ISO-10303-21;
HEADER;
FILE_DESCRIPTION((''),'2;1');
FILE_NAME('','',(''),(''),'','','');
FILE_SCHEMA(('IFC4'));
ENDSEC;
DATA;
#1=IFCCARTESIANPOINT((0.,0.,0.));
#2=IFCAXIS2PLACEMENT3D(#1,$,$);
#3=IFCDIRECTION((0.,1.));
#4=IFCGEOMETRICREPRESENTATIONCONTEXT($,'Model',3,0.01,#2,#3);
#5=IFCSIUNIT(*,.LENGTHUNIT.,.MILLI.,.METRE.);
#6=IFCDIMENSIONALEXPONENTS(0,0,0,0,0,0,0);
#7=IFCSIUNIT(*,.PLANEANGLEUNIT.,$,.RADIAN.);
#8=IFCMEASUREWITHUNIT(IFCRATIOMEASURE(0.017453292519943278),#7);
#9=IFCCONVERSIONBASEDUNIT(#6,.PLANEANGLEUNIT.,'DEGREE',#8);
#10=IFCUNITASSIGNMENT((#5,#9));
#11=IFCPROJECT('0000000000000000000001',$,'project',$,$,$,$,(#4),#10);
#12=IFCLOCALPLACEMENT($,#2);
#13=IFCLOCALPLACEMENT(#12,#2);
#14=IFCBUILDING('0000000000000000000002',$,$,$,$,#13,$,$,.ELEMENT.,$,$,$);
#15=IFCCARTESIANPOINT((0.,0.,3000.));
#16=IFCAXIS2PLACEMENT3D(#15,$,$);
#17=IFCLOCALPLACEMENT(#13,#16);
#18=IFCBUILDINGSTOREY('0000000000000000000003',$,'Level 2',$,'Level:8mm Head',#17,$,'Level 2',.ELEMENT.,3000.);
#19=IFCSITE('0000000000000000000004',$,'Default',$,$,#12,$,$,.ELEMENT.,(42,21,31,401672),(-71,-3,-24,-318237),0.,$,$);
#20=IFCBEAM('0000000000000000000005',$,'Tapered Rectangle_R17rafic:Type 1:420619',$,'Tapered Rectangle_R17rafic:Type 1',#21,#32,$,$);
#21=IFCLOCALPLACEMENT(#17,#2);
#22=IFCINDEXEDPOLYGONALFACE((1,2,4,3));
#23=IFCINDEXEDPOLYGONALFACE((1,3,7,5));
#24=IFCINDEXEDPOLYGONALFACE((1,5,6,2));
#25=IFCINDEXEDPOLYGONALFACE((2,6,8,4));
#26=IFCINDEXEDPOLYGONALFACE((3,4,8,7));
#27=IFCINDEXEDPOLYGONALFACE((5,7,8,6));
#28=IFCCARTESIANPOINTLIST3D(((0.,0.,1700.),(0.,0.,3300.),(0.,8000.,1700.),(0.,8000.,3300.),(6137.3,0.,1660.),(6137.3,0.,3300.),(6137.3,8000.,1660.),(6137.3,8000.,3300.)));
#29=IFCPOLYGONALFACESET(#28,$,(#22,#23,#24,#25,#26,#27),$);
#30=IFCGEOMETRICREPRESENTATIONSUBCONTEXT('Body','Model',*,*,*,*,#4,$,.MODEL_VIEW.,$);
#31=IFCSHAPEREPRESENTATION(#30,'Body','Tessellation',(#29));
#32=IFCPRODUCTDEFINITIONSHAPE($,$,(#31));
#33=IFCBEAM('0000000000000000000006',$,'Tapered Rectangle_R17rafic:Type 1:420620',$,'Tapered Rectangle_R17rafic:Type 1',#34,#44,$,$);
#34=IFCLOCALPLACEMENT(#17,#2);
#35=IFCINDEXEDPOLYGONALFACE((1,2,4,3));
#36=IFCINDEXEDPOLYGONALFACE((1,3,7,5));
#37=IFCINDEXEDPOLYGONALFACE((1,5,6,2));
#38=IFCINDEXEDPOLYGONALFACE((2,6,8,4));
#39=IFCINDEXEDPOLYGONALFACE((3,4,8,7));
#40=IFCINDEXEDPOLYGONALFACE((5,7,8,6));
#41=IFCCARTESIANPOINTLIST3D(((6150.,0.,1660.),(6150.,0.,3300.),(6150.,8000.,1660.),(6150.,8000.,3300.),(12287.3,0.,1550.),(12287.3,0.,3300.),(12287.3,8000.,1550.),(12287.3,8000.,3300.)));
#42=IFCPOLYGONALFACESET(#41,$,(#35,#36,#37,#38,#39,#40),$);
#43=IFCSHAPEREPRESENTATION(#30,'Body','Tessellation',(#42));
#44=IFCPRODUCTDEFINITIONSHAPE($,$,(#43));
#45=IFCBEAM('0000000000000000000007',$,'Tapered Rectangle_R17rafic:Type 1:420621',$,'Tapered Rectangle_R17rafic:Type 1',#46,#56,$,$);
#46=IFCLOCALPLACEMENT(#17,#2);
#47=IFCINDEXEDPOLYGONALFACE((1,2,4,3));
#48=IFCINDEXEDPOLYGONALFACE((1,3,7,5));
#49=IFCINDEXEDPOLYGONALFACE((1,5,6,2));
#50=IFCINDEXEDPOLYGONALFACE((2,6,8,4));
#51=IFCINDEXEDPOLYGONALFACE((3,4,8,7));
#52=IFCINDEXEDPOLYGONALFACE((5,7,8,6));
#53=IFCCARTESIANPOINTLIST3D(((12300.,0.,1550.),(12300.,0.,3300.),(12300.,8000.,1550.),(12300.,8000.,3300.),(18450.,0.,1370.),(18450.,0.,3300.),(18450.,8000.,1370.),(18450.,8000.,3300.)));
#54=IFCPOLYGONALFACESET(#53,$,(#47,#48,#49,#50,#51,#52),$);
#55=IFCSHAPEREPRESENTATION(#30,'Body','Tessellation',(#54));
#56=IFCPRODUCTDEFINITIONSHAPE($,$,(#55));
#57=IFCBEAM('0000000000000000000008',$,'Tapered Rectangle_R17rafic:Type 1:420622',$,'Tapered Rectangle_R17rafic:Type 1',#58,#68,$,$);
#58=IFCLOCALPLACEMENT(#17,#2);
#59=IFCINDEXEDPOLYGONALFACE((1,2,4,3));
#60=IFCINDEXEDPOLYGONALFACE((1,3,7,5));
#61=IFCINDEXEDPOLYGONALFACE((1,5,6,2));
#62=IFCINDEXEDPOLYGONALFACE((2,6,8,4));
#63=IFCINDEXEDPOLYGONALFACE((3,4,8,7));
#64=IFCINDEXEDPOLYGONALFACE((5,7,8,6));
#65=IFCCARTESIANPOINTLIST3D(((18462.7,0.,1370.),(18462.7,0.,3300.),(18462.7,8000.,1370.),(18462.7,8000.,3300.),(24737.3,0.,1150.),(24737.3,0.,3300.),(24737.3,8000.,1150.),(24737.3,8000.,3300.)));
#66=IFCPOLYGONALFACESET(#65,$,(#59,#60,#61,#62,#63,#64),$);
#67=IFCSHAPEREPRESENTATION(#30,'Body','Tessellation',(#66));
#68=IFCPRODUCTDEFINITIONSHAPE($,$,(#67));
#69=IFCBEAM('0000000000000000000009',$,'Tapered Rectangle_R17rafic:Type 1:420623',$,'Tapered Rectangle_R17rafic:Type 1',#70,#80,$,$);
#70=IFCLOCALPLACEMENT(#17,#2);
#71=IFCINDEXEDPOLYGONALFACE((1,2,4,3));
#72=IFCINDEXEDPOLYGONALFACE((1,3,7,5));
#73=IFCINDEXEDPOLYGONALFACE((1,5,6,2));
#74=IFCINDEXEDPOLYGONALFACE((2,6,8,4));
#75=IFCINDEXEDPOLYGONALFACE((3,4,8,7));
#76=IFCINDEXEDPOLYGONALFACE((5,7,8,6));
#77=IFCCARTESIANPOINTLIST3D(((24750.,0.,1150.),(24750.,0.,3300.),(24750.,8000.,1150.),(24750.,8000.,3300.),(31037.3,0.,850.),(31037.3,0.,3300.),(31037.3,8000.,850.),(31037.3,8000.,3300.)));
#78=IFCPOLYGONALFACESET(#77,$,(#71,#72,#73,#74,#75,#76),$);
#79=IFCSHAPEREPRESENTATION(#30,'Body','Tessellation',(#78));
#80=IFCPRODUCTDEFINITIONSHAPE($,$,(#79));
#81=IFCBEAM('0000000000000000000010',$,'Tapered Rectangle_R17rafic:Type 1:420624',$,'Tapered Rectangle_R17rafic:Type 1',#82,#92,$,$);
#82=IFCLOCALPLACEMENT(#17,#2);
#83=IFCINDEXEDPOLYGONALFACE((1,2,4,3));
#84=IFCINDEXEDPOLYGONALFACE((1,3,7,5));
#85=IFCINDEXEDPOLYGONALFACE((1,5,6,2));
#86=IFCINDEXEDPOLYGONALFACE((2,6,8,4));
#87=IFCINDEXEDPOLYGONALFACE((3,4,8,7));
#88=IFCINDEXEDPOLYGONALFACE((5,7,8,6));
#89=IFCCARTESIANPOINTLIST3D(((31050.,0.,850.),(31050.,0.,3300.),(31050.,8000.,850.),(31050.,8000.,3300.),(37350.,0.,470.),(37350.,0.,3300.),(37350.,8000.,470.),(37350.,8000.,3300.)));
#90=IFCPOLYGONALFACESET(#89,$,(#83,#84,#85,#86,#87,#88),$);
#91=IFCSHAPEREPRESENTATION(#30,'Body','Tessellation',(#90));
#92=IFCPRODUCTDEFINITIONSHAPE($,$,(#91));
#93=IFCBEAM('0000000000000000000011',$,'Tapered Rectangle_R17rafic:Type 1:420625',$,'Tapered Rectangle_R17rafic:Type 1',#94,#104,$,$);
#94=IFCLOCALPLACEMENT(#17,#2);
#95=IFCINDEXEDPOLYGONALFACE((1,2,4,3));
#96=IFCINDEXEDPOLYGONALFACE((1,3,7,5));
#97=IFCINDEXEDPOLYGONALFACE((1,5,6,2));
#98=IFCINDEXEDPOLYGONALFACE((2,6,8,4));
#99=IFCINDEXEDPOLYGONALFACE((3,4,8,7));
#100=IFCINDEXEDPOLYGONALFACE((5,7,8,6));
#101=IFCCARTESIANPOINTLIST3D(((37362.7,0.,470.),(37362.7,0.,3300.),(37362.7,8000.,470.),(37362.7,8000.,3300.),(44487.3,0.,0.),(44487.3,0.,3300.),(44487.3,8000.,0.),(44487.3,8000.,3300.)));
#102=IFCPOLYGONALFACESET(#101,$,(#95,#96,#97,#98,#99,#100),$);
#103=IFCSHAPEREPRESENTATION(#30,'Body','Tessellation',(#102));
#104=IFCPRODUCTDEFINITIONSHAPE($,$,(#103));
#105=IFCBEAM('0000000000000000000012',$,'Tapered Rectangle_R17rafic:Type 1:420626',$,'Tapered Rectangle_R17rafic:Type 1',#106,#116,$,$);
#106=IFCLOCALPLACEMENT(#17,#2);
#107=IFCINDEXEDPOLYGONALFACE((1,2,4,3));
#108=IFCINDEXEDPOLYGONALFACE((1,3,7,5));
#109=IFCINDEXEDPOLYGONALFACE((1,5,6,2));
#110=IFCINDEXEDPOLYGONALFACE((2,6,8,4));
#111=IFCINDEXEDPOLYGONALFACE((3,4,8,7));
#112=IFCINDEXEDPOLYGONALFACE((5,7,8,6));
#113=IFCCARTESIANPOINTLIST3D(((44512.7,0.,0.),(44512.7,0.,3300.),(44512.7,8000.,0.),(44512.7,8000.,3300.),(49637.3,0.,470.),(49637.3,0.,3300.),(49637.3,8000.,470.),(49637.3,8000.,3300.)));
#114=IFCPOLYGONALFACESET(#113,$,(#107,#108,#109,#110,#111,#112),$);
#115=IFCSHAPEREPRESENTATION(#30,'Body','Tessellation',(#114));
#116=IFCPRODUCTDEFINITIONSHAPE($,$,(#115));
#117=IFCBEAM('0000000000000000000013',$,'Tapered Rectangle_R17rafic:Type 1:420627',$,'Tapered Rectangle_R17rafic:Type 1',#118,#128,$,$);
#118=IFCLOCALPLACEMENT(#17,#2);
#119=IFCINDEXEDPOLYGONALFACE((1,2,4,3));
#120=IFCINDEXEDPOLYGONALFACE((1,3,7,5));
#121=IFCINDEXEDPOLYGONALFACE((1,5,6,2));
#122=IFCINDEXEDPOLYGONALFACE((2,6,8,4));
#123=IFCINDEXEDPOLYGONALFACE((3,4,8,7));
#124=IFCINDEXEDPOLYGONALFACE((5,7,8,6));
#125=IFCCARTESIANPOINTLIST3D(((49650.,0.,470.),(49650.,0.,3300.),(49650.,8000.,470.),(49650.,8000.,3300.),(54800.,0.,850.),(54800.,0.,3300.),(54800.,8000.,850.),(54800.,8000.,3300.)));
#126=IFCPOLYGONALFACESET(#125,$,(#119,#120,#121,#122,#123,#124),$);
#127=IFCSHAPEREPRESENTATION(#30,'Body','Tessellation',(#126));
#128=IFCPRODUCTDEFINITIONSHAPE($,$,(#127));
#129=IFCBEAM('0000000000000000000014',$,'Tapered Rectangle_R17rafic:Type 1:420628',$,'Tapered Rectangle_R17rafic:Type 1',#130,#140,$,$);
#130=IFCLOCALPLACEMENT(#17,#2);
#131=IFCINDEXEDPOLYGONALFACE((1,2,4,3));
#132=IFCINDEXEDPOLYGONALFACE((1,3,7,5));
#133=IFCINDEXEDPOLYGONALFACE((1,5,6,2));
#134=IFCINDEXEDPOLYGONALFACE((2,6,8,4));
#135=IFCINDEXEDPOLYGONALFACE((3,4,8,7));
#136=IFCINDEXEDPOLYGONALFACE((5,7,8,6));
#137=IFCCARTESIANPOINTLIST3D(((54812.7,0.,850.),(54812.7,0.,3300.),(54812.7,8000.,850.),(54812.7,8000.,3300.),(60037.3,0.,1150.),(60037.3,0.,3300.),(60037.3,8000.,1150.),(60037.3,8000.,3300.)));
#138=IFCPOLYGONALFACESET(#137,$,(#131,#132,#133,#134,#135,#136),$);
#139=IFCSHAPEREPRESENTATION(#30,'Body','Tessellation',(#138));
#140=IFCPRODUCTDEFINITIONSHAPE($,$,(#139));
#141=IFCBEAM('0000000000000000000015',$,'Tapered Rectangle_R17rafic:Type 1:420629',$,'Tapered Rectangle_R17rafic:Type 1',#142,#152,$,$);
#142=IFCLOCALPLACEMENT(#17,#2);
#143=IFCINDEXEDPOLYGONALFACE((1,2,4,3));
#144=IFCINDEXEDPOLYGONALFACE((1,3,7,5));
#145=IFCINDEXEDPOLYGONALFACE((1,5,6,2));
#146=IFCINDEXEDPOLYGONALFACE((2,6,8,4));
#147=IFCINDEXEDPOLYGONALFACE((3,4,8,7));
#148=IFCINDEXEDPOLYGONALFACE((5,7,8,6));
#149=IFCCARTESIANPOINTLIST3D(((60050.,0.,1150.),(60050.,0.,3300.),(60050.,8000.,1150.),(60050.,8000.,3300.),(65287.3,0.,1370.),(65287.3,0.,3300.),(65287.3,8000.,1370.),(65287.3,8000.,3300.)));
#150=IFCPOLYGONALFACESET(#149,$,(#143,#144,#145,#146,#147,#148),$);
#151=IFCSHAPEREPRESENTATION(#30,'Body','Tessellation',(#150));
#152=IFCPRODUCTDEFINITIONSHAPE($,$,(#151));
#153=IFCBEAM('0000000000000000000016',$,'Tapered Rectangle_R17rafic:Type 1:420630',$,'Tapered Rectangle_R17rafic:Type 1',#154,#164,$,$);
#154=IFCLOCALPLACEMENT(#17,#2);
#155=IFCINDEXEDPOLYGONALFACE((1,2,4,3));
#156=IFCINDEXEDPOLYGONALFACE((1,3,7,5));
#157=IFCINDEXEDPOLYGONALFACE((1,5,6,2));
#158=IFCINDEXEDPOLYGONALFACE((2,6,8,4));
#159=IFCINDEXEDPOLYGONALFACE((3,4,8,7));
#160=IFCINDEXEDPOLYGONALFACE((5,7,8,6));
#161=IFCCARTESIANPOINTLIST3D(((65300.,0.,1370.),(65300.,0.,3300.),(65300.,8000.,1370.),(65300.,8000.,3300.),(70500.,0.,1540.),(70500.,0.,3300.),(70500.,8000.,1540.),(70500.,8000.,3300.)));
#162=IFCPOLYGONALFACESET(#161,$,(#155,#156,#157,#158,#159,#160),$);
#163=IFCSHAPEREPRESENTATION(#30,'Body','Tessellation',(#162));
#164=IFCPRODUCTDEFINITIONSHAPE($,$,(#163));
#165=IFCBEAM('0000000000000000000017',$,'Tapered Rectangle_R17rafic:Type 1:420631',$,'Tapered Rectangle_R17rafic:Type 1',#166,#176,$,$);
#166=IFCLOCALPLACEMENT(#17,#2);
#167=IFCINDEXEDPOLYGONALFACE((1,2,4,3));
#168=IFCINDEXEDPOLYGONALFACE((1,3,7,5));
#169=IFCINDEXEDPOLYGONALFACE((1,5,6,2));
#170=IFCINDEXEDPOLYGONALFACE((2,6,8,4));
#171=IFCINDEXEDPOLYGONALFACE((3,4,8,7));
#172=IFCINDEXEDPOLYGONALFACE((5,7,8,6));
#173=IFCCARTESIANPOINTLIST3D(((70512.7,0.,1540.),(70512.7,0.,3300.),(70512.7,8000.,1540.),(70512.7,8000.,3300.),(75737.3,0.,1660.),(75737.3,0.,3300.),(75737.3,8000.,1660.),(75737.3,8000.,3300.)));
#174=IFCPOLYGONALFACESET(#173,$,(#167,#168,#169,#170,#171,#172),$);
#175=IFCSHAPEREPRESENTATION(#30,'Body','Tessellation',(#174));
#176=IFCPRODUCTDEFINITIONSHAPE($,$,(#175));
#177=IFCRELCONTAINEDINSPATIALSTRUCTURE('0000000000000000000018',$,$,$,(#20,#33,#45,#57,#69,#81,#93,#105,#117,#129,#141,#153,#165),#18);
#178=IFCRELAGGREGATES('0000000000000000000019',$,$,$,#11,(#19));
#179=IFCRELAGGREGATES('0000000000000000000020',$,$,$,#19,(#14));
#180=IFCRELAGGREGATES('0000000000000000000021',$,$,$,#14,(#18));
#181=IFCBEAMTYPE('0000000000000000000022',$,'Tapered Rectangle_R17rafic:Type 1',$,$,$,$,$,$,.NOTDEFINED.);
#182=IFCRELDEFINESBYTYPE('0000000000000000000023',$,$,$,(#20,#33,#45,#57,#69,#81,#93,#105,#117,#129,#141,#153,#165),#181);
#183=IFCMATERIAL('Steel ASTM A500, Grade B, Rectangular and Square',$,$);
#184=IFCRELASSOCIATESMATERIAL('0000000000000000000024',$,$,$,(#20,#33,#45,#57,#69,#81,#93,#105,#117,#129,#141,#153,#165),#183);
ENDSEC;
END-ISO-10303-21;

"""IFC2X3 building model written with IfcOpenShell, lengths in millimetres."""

from ifc_helpers import new_model, entity, si_unit, converted_unit, direction, frame, frame_2d, origin, place, context, subcontext, project, spatial, rectangle, extrude, clip, halfspace, material, type_object, element, save


model = new_model("IFC2X3")

# Units and contexts
model_context = context("Model", 3, precision=0.01, world=origin(), true_north=direction((0.0, 1.0)))
body_context = subcontext(model_context, "Body", "Model", "MODEL_VIEW")
ifc_project = project(units=[si_unit("LENGTHUNIT", "METRE", prefix="MILLI"), converted_unit("PLANEANGLEUNIT", "DEGREE", entity("IfcRatioMeasure", 0.017453292519943278), si_unit("PLANEANGLEUNIT", "RADIAN"), dimensions=[0, 0, 0, 0, 0, 0, 0])], contexts=[model_context])

# Site, building, storey
site_placement = place(None, origin())
site = spatial("IfcSite", under=ifc_project, at=site_placement, Name="Default", CompositionType="ELEMENT", RefLatitude=(42, 21, 31, 401672), RefLongitude=(-71, -3, -24, -318237), RefElevation=0.0)
building_placement = place(site_placement, origin())
building = spatial("IfcBuilding", under=site, at=building_placement, CompositionType="ELEMENT")
storey_placement = place(building_placement, frame((0.0, 0.0, 3000.0)))
storey = spatial("IfcBuildingStorey", under=building, at=storey_placement, Name="Level 2", ObjectType="Level:8mm Head", LongName="Level 2", CompositionType="ELEMENT", Elevation=3000.0)

# Beams
ifc_material = material(Name="Steel ASTM A500, Grade B, Rectangular and Square")
beam_type = type_object("IfcBeamType", Name="Tapered Rectangle_R17rafic:Type 1", PredefinedType="NOTDEFINED")
beam_1_placement = place(storey_placement, frame((0.0, 4000.0, 3300.0)))
element("IfcBeam", 1, at=beam_1_placement, inside=storey, type_object=beam_type, material=ifc_material, Name="Tapered Rectangle_R17rafic:Type 1:420619", ObjectType="Tapered Rectangle_R17rafic:Type 1", context=body_context, shape_type="SweptSolid", body=[
    clip(extrude(rectangle(XDim=1640.0, YDim=8000.0, at=frame_2d((0.0, 0.0), x_axis=(0.0, 1.0))), frame((0.0, 0.0, -820.0), z_axis=(1.0, 0.0, 0.0), x_axis=(0.0, 1.0, 0.0)), (0.0, 0.0, 1.0), 6137.3), halfspace(frame((0.0, 0.0, -1600.0), z_axis=(-0.006517, 0.0, -0.999979), x_axis=(0.0, 1.0, 0.0)), False)),
])
beam_2_placement = place(storey_placement, frame((6150.0, 4000.0, 3300.0)))
element("IfcBeam", 2, at=beam_2_placement, inside=storey, type_object=beam_type, material=ifc_material, Name="Tapered Rectangle_R17rafic:Type 1:420620", ObjectType="Tapered Rectangle_R17rafic:Type 1", context=body_context, shape_type="SweptSolid", body=[
    clip(extrude(rectangle(XDim=1750.0, YDim=8000.0, at=frame_2d((0.0, 0.0), x_axis=(0.0, 1.0))), frame((0.0, 0.0, -875.0), z_axis=(1.0, 0.0, 0.0), x_axis=(0.0, 1.0, 0.0)), (0.0, 0.0, 1.0), 6137.3), halfspace(frame((0.0, 0.0, -1640.0), z_axis=(-0.01792, 0.0, -0.999839), x_axis=(0.0, 1.0, 0.0)), False)),
])
beam_3_placement = place(storey_placement, frame((12300.0, 4000.0, 3300.0)))
element("IfcBeam", 3, at=beam_3_placement, inside=storey, type_object=beam_type, material=ifc_material, Name="Tapered Rectangle_R17rafic:Type 1:420621", ObjectType="Tapered Rectangle_R17rafic:Type 1", context=body_context, shape_type="SweptSolid", body=[
    clip(extrude(rectangle(XDim=1930.0, YDim=8000.0, at=frame_2d((0.0, 0.0), x_axis=(0.0, 1.0))), frame((0.0, 0.0, -965.0), z_axis=(1.0, 0.0, 0.0), x_axis=(0.0, 1.0, 0.0)), (0.0, 0.0, 1.0), 6150.0), halfspace(frame((0.0, 0.0, -1750.0), z_axis=(-0.029256, 0.0, -0.999572), x_axis=(0.0, 1.0, 0.0)), False)),
])
beam_4_placement = place(storey_placement, frame((18450.0, 4000.0, 3300.0)))
element("IfcBeam", 4, at=beam_4_placement, inside=storey, type_object=beam_type, material=ifc_material, Name="Tapered Rectangle_R17rafic:Type 1:420622", ObjectType="Tapered Rectangle_R17rafic:Type 1", context=body_context, shape_type="SweptSolid", body=[
    clip(extrude(rectangle(XDim=2150.0, YDim=8000.0, at=frame_2d((0.0, 0.0), x_axis=(0.0, 1.0))), frame((12.7, 0.0, -1075.0), z_axis=(1.0, 0.0, 0.0), x_axis=(0.0, 1.0, 0.0)), (0.0, 0.0, 1.0), 6274.6), halfspace(frame((12.7, 0.0, -1930.0), z_axis=(-0.03504, 0.0, -0.999386), x_axis=(0.0, 1.0, 0.0)), False)),
])
beam_5_placement = place(storey_placement, frame((24750.0, 4000.0, 3300.0)))
element("IfcBeam", 5, at=beam_5_placement, inside=storey, type_object=beam_type, material=ifc_material, Name="Tapered Rectangle_R17rafic:Type 1:420623", ObjectType="Tapered Rectangle_R17rafic:Type 1", context=body_context, shape_type="SweptSolid", body=[
    clip(extrude(rectangle(XDim=2450.0, YDim=8000.0, at=frame_2d((0.0, 0.0), x_axis=(0.0, 1.0))), frame((0.0, 0.0, -1225.0), z_axis=(1.0, 0.0, 0.0), x_axis=(0.0, 1.0, 0.0)), (0.0, 0.0, 1.0), 6287.3), halfspace(frame((0.0, 0.0, -2150.0), z_axis=(-0.047661, 0.0, -0.998864), x_axis=(0.0, 1.0, 0.0)), False)),
])
beam_6_placement = place(storey_placement, frame((31050.0, 4000.0, 3300.0)))
element("IfcBeam", 6, at=beam_6_placement, inside=storey, type_object=beam_type, material=ifc_material, Name="Tapered Rectangle_R17rafic:Type 1:420624", ObjectType="Tapered Rectangle_R17rafic:Type 1", context=body_context, shape_type="SweptSolid", body=[
    clip(extrude(rectangle(XDim=2830.0, YDim=8000.0, at=frame_2d((0.0, 0.0), x_axis=(0.0, 1.0))), frame((0.0, 0.0, -1415.0), z_axis=(1.0, 0.0, 0.0), x_axis=(0.0, 1.0, 0.0)), (0.0, 0.0, 1.0), 6300.0), halfspace(frame((0.0, 0.0, -2450.0), z_axis=(-0.060208, 0.0, -0.998186), x_axis=(0.0, 1.0, 0.0)), False)),
])
beam_7_placement = place(storey_placement, frame((37350.0, 4000.0, 3300.0)))
element("IfcBeam", 7, at=beam_7_placement, inside=storey, type_object=beam_type, material=ifc_material, Name="Tapered Rectangle_R17rafic:Type 1:420625", ObjectType="Tapered Rectangle_R17rafic:Type 1", context=body_context, shape_type="SweptSolid", body=[
    clip(extrude(rectangle(XDim=3300.0, YDim=8000.0, at=frame_2d((0.0, 0.0), x_axis=(0.0, 1.0))), frame((12.7, 0.0, -1650.0), z_axis=(1.0, 0.0, 0.0), x_axis=(0.0, 1.0, 0.0)), (0.0, 0.0, 1.0), 7124.6), halfspace(frame((12.7, 0.0, -2830.0), z_axis=(-0.065826, 0.0, -0.997831), x_axis=(0.0, 1.0, 0.0)), False)),
])
beam_8_placement = place(storey_placement, frame((44500.0, 4000.0, 3300.0)))
element("IfcBeam", 8, at=beam_8_placement, inside=storey, type_object=beam_type, material=ifc_material, Name="Tapered Rectangle_R17rafic:Type 1:420626", ObjectType="Tapered Rectangle_R17rafic:Type 1", context=body_context, shape_type="SweptSolid", body=[
    clip(extrude(rectangle(XDim=3300.0, YDim=8000.0, at=frame_2d((0.0, 0.0), x_axis=(0.0, 1.0))), frame((12.7, 0.0, -1650.0), z_axis=(1.0, 0.0, 0.0), x_axis=(0.0, 1.0, 0.0)), (0.0, 0.0, 1.0), 5124.6), halfspace(frame((12.7, 0.0, -3300.0), z_axis=(0.091331, 0.0, -0.995821), x_axis=(0.0, 1.0, 0.0)), False)),
])
beam_9_placement = place(storey_placement, frame((49650.0, 4000.0, 3300.0)))
element("IfcBeam", 9, at=beam_9_placement, inside=storey, type_object=beam_type, material=ifc_material, Name="Tapered Rectangle_R17rafic:Type 1:420627", ObjectType="Tapered Rectangle_R17rafic:Type 1", context=body_context, shape_type="SweptSolid", body=[
    clip(extrude(rectangle(XDim=2830.0, YDim=8000.0, at=frame_2d((0.0, 0.0), x_axis=(0.0, 1.0))), frame((0.0, 0.0, -1415.0), z_axis=(1.0, 0.0, 0.0), x_axis=(0.0, 1.0, 0.0)), (0.0, 0.0, 1.0), 5150.0), halfspace(frame((0.0, 0.0, -2830.0), z_axis=(0.073586, 0.0, -0.997289), x_axis=(0.0, 1.0, 0.0)), False)),
])
beam_10_placement = place(storey_placement, frame((54800.0, 4000.0, 3300.0)))
element("IfcBeam", 10, at=beam_10_placement, inside=storey, type_object=beam_type, material=ifc_material, Name="Tapered Rectangle_R17rafic:Type 1:420628", ObjectType="Tapered Rectangle_R17rafic:Type 1", context=body_context, shape_type="SweptSolid", body=[
    clip(extrude(rectangle(XDim=2450.0, YDim=8000.0, at=frame_2d((0.0, 0.0), x_axis=(0.0, 1.0))), frame((12.7, 0.0, -1225.0), z_axis=(1.0, 0.0, 0.0), x_axis=(0.0, 1.0, 0.0)), (0.0, 0.0, 1.0), 5224.6), halfspace(frame((12.7, 0.0, -2450.0), z_axis=(0.057326, 0.0, -0.998355), x_axis=(0.0, 1.0, 0.0)), False)),
])
beam_11_placement = place(storey_placement, frame((60050.0, 4000.0, 3300.0)))
element("IfcBeam", 11, at=beam_11_placement, inside=storey, type_object=beam_type, material=ifc_material, Name="Tapered Rectangle_R17rafic:Type 1:420629", ObjectType="Tapered Rectangle_R17rafic:Type 1", context=body_context, shape_type="SweptSolid", body=[
    clip(extrude(rectangle(XDim=2150.0, YDim=8000.0, at=frame_2d((0.0, 0.0), x_axis=(0.0, 1.0))), frame((0.0, 0.0, -1075.0), z_axis=(1.0, 0.0, 0.0), x_axis=(0.0, 1.0, 0.0)), (0.0, 0.0, 1.0), 5237.3), halfspace(frame((0.0, 0.0, -2150.0), z_axis=(0.041969, 0.0, -0.999119), x_axis=(0.0, 1.0, 0.0)), False)),
])
beam_12_placement = place(storey_placement, frame((65300.0, 4000.0, 3300.0)))
element("IfcBeam", 12, at=beam_12_placement, inside=storey, type_object=beam_type, material=ifc_material, Name="Tapered Rectangle_R17rafic:Type 1:420630", ObjectType="Tapered Rectangle_R17rafic:Type 1", context=body_context, shape_type="SweptSolid", body=[
    clip(extrude(rectangle(XDim=1930.0, YDim=8000.0, at=frame_2d((0.0, 0.0), x_axis=(0.0, 1.0))), frame((0.0, 0.0, -965.0), z_axis=(1.0, 0.0, 0.0), x_axis=(0.0, 1.0, 0.0)), (0.0, 0.0, 1.0), 5200.0), halfspace(frame((0.0, 0.0, -1930.0), z_axis=(0.032675, 0.0, -0.999466), x_axis=(0.0, 1.0, 0.0)), False)),
])
beam_13_placement = place(storey_placement, frame((70500.0, 4000.0, 3300.0)))
element("IfcBeam", 13, at=beam_13_placement, inside=storey, type_object=beam_type, material=ifc_material, Name="Tapered Rectangle_R17rafic:Type 1:420631", ObjectType="Tapered Rectangle_R17rafic:Type 1", context=body_context, shape_type="SweptSolid", body=[
    clip(extrude(rectangle(XDim=1760.0, YDim=8000.0, at=frame_2d((0.0, 0.0), x_axis=(0.0, 1.0))), frame((12.7, 0.0, -880.0), z_axis=(1.0, 0.0, 0.0), x_axis=(0.0, 1.0, 0.0)), (0.0, 0.0, 1.0), 5224.6), halfspace(frame((12.7, 0.0, -1760.0), z_axis=(0.022962, 0.0, -0.999736), x_axis=(0.0, 1.0, 0.0)), False)),
])

save(model, "model.ifc")
